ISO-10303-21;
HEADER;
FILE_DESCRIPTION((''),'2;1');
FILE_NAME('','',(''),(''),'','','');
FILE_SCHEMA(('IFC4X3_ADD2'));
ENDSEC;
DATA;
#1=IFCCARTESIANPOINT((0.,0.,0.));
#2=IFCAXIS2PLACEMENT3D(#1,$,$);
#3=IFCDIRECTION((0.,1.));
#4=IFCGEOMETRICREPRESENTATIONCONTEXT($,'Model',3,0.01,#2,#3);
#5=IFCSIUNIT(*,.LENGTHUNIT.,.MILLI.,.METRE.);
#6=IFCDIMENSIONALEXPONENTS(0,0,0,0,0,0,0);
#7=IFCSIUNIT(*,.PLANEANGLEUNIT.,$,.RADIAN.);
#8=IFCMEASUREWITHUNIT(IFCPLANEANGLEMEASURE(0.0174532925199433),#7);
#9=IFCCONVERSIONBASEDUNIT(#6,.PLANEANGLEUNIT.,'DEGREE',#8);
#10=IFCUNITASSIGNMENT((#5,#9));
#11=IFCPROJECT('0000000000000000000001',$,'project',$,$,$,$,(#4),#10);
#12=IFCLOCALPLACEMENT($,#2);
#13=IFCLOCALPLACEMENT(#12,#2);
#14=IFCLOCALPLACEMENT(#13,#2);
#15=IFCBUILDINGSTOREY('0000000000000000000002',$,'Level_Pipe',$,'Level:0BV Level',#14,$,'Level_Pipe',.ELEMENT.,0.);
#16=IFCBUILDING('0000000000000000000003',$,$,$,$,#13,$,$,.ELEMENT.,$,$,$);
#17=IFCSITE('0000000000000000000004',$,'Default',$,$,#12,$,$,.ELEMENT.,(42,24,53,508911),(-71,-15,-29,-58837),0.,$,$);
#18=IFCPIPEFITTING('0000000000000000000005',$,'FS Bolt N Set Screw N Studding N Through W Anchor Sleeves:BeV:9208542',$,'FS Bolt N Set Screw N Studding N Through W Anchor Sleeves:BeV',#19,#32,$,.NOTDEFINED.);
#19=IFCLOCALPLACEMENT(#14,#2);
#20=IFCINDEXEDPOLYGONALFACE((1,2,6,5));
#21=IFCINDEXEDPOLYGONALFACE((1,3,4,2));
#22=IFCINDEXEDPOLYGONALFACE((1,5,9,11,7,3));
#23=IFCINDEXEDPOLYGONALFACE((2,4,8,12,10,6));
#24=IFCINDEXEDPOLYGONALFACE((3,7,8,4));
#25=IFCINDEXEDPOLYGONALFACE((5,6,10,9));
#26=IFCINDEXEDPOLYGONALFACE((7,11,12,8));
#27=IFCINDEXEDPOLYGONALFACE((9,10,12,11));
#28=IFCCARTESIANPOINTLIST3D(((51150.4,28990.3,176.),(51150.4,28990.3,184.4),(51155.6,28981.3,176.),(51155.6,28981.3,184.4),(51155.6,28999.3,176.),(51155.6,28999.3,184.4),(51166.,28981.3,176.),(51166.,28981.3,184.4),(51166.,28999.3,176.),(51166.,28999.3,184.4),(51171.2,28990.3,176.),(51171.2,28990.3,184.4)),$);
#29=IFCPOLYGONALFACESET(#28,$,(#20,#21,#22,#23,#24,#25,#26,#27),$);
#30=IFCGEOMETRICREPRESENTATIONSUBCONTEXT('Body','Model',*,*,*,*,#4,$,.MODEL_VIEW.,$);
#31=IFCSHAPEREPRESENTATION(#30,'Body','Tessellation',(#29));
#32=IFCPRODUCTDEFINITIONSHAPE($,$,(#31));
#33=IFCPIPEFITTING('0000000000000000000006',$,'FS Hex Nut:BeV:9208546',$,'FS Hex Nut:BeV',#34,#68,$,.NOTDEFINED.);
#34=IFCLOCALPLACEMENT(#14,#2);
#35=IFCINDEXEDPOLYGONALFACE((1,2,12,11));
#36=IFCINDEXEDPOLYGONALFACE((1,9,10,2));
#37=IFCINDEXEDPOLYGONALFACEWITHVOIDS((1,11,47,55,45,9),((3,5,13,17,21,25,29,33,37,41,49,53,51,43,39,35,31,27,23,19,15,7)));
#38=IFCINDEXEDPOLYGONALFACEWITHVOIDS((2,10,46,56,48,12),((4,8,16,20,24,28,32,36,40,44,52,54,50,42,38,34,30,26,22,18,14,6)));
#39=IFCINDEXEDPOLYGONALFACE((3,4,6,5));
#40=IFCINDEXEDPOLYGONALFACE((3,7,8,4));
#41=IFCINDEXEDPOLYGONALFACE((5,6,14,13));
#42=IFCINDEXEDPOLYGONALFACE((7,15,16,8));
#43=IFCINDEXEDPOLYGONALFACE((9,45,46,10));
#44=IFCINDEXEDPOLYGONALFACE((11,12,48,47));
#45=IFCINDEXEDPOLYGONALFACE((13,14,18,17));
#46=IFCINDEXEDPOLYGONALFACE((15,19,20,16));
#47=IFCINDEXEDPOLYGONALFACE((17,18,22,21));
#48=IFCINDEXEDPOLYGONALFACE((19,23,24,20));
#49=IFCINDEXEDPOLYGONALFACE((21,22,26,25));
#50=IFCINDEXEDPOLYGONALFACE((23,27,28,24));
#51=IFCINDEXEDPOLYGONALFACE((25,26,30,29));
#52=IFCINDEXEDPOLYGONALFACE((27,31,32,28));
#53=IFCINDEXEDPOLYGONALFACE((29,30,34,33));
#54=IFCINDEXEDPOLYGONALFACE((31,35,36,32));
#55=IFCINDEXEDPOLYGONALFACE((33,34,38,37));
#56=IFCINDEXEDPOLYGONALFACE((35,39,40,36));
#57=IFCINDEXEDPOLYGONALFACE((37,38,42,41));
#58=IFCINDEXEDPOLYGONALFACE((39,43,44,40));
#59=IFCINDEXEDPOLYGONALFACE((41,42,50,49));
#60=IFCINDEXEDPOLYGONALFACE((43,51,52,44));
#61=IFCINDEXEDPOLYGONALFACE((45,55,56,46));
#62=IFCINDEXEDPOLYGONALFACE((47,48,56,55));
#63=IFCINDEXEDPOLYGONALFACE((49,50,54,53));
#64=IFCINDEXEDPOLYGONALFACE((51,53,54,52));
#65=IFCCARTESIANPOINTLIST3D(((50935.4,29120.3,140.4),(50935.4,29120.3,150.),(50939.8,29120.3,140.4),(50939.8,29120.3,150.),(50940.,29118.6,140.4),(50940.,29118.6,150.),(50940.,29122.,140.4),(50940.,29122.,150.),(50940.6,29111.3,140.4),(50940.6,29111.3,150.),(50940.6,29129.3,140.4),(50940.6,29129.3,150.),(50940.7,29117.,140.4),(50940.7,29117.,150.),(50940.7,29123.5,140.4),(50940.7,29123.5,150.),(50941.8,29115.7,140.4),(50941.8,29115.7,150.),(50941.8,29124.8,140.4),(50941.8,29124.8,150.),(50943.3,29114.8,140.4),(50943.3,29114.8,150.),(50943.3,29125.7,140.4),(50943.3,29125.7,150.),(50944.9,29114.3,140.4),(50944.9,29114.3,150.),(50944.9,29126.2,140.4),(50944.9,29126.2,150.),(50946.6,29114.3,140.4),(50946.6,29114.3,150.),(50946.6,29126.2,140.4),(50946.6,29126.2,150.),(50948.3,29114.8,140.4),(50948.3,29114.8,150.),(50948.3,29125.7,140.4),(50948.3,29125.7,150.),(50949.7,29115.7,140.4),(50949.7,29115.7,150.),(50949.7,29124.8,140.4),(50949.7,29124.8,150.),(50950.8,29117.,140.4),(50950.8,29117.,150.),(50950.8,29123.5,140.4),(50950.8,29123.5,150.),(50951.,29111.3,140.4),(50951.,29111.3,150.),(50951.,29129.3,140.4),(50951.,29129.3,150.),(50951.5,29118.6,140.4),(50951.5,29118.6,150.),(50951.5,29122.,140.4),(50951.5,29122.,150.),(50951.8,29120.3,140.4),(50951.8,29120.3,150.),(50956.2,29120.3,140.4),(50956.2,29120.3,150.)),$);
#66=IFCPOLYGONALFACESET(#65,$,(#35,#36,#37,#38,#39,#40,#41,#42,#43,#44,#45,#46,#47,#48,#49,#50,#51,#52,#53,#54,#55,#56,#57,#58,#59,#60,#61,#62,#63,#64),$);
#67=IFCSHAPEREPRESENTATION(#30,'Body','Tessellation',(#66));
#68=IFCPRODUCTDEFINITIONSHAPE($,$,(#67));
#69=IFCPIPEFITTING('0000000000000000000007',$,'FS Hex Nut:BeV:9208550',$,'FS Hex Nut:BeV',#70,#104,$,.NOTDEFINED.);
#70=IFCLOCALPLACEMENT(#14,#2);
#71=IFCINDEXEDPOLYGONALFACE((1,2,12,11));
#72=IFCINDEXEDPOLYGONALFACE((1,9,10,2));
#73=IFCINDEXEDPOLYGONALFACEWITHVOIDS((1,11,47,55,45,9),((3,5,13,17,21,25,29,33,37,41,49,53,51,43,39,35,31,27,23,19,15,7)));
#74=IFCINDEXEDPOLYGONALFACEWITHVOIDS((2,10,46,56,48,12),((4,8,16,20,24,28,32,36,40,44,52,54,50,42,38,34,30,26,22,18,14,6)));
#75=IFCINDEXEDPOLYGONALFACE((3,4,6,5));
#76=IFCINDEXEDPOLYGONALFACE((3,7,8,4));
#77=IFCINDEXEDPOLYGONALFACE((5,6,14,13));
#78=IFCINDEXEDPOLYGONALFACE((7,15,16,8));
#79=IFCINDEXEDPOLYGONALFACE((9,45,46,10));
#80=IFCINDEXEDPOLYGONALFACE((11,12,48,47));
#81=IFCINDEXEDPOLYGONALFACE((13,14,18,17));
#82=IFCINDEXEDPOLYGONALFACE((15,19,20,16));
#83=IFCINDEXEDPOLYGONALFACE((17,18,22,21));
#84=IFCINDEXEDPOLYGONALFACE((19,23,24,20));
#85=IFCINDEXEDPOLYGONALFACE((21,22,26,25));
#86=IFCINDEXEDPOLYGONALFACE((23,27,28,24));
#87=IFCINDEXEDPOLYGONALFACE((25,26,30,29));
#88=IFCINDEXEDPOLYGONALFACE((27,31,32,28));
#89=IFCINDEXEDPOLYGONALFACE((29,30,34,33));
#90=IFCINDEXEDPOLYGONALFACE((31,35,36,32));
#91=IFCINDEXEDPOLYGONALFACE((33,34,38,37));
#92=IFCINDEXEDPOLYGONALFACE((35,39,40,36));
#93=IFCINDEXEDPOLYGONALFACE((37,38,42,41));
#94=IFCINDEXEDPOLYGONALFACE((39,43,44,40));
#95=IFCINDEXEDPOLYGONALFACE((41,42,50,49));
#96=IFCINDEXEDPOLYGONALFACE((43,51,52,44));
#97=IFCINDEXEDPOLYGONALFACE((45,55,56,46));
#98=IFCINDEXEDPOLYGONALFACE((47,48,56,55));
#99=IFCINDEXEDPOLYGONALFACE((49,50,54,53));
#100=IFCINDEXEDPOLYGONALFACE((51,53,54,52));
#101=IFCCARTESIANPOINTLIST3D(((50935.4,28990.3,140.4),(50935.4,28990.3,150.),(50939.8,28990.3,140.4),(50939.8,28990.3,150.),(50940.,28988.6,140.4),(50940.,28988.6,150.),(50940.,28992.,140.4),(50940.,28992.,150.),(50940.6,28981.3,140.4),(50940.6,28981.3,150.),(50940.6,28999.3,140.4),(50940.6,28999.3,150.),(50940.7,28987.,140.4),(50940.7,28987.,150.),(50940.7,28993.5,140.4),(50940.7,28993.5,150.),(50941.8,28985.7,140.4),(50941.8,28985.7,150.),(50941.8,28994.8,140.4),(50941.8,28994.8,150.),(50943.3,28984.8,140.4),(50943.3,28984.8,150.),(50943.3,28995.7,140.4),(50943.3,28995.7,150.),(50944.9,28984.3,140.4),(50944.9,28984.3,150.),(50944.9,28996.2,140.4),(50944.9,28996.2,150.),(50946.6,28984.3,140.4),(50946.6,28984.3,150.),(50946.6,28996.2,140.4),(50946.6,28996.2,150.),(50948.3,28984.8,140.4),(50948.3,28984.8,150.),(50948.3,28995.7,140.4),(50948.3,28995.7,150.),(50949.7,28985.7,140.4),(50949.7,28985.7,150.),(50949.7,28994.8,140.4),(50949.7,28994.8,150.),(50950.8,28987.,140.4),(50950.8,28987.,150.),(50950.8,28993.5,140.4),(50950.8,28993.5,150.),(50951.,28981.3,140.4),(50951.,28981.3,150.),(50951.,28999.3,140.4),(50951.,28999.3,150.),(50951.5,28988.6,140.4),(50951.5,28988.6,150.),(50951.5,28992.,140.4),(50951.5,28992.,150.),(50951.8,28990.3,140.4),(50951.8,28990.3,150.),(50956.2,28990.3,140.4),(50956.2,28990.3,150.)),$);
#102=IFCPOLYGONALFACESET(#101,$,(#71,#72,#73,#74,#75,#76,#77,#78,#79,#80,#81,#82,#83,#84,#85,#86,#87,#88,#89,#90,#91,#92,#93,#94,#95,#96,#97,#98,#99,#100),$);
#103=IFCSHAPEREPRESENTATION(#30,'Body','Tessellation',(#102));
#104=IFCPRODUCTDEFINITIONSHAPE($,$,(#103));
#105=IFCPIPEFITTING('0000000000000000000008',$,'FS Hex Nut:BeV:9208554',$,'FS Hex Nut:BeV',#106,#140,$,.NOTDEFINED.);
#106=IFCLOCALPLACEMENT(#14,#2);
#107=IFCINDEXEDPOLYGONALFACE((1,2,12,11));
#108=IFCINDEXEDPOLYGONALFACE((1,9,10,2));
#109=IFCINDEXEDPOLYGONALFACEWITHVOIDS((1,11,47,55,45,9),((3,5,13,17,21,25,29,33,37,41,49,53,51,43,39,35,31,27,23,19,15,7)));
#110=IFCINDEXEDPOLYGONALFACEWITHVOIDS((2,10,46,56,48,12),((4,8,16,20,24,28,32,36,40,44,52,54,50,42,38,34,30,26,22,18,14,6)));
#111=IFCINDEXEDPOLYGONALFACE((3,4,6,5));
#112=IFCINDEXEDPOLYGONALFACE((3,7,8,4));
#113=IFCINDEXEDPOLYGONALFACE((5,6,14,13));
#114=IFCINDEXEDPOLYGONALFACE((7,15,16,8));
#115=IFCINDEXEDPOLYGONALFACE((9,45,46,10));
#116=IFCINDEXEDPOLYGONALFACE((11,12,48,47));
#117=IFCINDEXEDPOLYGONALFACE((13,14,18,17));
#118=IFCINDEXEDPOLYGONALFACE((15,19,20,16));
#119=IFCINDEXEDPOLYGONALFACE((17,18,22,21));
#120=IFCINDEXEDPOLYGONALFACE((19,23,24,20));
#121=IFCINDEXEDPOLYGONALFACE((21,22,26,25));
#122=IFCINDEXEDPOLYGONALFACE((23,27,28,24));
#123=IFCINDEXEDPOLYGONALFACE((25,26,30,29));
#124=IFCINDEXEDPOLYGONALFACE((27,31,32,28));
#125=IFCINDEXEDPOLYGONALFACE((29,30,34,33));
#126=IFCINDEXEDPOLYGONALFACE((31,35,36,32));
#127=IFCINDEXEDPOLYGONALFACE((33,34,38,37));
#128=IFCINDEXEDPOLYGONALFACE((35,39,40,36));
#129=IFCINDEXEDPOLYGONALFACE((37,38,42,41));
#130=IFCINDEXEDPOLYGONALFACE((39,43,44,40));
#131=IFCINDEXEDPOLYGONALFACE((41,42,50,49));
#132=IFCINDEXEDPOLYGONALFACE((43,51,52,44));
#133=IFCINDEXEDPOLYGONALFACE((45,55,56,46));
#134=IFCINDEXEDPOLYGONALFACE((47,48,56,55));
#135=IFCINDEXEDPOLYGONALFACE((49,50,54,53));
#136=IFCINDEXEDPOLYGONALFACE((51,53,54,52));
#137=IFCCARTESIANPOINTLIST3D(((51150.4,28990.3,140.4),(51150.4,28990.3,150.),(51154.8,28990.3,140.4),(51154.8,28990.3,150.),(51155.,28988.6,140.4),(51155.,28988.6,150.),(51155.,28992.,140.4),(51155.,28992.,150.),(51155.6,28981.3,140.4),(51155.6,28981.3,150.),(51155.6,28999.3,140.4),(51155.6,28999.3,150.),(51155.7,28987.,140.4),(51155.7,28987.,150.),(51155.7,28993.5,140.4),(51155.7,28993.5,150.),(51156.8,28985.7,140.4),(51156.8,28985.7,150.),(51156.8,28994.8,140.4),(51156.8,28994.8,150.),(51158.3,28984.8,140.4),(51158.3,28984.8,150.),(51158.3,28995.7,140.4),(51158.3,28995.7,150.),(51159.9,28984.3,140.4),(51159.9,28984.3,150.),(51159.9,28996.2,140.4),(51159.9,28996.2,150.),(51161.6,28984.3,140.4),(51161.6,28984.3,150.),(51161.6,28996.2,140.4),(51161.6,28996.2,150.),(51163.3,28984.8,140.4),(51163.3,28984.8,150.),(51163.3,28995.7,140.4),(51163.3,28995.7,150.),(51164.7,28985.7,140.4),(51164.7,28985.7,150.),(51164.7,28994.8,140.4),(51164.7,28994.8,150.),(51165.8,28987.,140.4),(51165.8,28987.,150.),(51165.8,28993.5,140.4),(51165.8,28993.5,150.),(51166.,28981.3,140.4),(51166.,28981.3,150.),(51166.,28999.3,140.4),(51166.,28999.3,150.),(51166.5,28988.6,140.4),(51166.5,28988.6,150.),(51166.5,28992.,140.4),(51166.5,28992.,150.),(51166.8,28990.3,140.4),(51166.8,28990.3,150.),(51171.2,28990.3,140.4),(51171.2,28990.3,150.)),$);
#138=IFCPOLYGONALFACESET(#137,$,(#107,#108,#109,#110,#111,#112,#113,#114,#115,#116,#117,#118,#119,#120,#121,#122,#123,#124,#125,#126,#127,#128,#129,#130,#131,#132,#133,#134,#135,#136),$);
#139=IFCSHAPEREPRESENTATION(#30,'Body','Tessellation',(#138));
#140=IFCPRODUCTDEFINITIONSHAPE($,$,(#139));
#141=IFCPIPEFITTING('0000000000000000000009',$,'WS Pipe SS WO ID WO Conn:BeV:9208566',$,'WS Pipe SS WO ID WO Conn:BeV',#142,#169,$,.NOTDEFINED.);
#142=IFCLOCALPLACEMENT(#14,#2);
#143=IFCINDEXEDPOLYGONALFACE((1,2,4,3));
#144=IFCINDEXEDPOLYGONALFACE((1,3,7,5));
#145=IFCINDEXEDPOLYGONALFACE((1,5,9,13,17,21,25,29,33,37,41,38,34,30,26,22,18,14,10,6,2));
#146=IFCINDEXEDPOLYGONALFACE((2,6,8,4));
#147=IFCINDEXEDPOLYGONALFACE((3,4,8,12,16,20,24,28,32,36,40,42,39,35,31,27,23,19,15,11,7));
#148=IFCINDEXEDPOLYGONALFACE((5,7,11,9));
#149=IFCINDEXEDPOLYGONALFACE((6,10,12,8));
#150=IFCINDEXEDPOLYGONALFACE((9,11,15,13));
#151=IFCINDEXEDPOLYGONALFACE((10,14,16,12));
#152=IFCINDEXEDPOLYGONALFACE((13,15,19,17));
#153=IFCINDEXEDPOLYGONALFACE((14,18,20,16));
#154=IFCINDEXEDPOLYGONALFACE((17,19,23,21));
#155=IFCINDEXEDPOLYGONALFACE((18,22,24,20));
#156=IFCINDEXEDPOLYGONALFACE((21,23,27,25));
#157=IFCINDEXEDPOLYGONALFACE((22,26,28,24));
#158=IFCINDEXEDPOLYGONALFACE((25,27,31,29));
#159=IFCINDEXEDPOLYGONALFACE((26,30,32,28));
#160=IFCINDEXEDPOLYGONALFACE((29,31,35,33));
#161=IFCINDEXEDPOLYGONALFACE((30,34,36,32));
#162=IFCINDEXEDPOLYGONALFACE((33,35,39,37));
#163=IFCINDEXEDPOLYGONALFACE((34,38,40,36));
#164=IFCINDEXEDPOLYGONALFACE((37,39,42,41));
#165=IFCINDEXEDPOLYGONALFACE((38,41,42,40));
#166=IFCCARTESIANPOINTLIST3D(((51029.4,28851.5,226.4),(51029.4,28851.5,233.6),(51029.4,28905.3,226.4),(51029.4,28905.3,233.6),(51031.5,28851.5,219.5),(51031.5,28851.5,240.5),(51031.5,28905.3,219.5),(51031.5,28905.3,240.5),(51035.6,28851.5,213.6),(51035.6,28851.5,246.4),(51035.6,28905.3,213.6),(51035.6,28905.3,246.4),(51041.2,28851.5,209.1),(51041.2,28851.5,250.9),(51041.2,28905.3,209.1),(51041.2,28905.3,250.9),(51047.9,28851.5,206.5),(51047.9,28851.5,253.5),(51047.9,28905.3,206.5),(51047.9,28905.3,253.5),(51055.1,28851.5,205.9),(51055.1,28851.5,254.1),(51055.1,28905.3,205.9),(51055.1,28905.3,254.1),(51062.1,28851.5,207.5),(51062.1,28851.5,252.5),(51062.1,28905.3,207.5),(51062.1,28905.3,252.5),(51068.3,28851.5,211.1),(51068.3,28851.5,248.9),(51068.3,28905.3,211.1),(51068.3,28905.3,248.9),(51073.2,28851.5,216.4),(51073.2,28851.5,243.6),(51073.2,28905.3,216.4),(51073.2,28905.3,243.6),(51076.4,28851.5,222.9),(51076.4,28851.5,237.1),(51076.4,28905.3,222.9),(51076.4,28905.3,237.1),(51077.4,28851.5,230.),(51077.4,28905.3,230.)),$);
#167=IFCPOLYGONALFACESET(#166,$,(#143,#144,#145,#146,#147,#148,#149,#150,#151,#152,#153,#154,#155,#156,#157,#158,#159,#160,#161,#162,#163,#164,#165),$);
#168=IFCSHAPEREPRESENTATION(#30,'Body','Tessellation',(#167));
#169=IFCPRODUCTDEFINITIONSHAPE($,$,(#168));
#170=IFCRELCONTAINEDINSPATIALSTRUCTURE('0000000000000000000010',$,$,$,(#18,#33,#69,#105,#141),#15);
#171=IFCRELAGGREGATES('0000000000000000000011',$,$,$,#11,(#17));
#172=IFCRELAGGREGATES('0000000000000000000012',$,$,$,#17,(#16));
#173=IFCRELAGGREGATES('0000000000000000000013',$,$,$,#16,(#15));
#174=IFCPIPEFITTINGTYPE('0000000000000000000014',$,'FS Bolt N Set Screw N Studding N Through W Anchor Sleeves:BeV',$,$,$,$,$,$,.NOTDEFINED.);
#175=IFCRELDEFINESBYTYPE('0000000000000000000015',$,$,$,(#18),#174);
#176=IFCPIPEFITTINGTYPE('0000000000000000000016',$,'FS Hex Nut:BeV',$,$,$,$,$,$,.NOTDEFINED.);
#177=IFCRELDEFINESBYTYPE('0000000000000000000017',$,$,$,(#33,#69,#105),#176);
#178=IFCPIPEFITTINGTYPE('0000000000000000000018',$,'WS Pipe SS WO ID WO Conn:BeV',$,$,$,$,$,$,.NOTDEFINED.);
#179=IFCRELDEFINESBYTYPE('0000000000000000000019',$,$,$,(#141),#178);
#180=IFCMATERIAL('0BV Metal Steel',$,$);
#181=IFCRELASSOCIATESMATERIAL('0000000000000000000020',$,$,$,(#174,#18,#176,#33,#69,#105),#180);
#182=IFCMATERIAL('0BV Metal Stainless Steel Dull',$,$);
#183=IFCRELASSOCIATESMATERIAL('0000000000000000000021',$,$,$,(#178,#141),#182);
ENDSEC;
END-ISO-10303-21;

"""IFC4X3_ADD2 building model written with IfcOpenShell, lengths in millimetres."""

from ifc_helpers import new_model, entity, si_unit, converted_unit, direction, frame, frame_2d, origin, place, context, subcontext, project, spatial, polyline, circle_curve, parameter, trimmed, segment, composite_curve, circle, outline, extrude, source, transform, mapped, material, type_object, type_shapes, element, save


model = new_model("IFC4X3_ADD2")

# Units and contexts
model_context = context("Model", 3, precision=0.01, world=origin(), true_north=direction((0.0, 1.0)))
body_context = subcontext(model_context, "Body", "Model", "MODEL_VIEW")
ifc_project = project(units=[si_unit("LENGTHUNIT", "METRE", prefix="MILLI"), converted_unit("PLANEANGLEUNIT", "DEGREE", entity("IfcPlaneAngleMeasure", 0.0174532925199433), si_unit("PLANEANGLEUNIT", "RADIAN"), dimensions=[0, 0, 0, 0, 0, 0, 0])], contexts=[model_context])

# Site, building, storey
site_placement = place(None, origin())
site = spatial("IfcSite", under=ifc_project, at=site_placement, Name="Default", CompositionType="ELEMENT", RefLatitude=(42, 24, 53, 508911), RefLongitude=(-71, -15, -29, -58837), RefElevation=0.0)
building_placement = place(site_placement, origin())
building = spatial("IfcBuilding", under=site, at=building_placement, CompositionType="ELEMENT")
storey_placement = place(building_placement, origin())
storey = spatial("IfcBuildingStorey", under=building, at=storey_placement, Name="Level_Pipe", ObjectType="Level:0BV Level", LongName="Level_Pipe", CompositionType="ELEMENT", Elevation=0.0)

# Pipe fittings
ifc_material_1 = material(Name="0BV Metal Stainless Steel Dull")
ifc_material_2 = material(Name="0BV Metal Steel")
pipe_fitting_type_1 = type_object("IfcPipeFittingType", Name="FS Bolt N Set Screw N Studding N Through W Anchor Sleeves:BeV", PredefinedType="NOTDEFINED", material=ifc_material_2)
shared_shape_1 = source(origin(), body_context, "Body", "SweptSolid", [
    extrude(outline(polyline([(-5.2, -9.0), (5.2, -9.0), (10.4, 0.0), (5.2, 9.0), (-5.2, 9.0), (-10.4, 0.0), (-5.2, -9.0)])), frame((-8.4, 0.0, 0.0), z_axis=(1.0, 0.0, 0.0), x_axis=(0.0, -0.5, -0.866025)), (0.0, 0.0, 1.0), 8.4),
])
type_shapes(pipe_fitting_type_1, [shared_shape_1])
pipe_fitting_1_placement = place(storey_placement, frame((51160.8, 28990.3, 176.0), z_axis=(0.0, 1.0, 0.0), x_axis=(0.0, 0.0, -1.0)))
element("IfcPipeFitting", 1, at=pipe_fitting_1_placement, inside=storey, type_object=pipe_fitting_type_1, material=ifc_material_2, Name="FS Bolt N Set Screw N Studding N Through W Anchor Sleeves:BeV:9208542", ObjectType="FS Bolt N Set Screw N Studding N Through W Anchor Sleeves:BeV", PredefinedType="NOTDEFINED", context=body_context, shape_type="MappedRepresentation", body=[
    mapped(shared_shape_1, transform((0.0, 0.0, 0.0), scale=1.0)),
])
pipe_fitting_type_2 = type_object("IfcPipeFittingType", Name="FS Hex Nut:BeV", PredefinedType="NOTDEFINED", material=ifc_material_2)
shared_shape_2 = source(origin(), body_context, "Body", "SweptSolid", [
    extrude(outline(polyline([(-5.2, -9.0), (5.2, -9.0), (10.4, 0.0), (5.2, 9.0), (-5.2, 9.0), (-10.4, 0.0), (-5.2, -9.0)]), holes=[composite_curve([segment(trimmed(circle_curve(frame_2d((0.0, 0.0), x_axis=(-0.5, 0.866025)), 6.0), [parameter(0.0)], [parameter(180.0)], True, "PARAMETER"), False, "CONTINUOUS"), segment(trimmed(circle_curve(frame_2d((0.0, 0.0), x_axis=(-0.5, 0.866025)), 6.0), [parameter(180.0)], [parameter(360.0)], True, "PARAMETER"), False, "CONTINUOUS")], self_intersect=False)]), frame((0.0, 10.4, 9.0), z_axis=(1.0, 0.0, 0.0), x_axis=(0.0, -0.5, -0.866025)), (0.0, 0.0, 1.0), 9.6),
])
type_shapes(pipe_fitting_type_2, [shared_shape_2])
for number, where, z_axis, x_axis, name in (
    (2, (50956.2, 29111.3, 150.0), (0.0, 1.0, 0.0), (0.0, 0.0, -1.0), "FS Hex Nut:BeV:9208546"),
    (3, (50956.2, 28981.3, 150.0), (0.0, 1.0, 0.0), (0.0, 0.0, -1.0), "FS Hex Nut:BeV:9208550"),
    (4, (51171.2, 28981.3, 150.0), (0.0, 1.0, 0.0), (0.0, 0.0, -1.0), "FS Hex Nut:BeV:9208554"),
):
    element("IfcPipeFitting", number, at=place(storey_placement, frame(where, z_axis=z_axis, x_axis=x_axis)), inside=storey, type_object=pipe_fitting_type_2, material=ifc_material_2, Name=name, ObjectType="FS Hex Nut:BeV", PredefinedType="NOTDEFINED", context=body_context, shape_type="MappedRepresentation", body=[
        mapped(shared_shape_2, transform((0.0, 0.0, 0.0), scale=1.0)),
    ])
pipe_fitting_type_3 = type_object("IfcPipeFittingType", Name="WS Pipe SS WO ID WO Conn:BeV", PredefinedType="NOTDEFINED", material=ifc_material_1)
shared_shape_3 = source(origin(), body_context, "Body", "SweptSolid", [
    extrude(circle(Radius=24.1, at=frame_2d((0.0, 0.0), x_axis=(1.0, 0.0))), frame((-26.9, 0.0, 0.0), z_axis=(1.0, 0.0, 0.0), x_axis=(0.0, 1.0, 0.0)), (0.0, 0.0, 1.0), 53.8),
])
type_shapes(pipe_fitting_type_3, [shared_shape_3])
pipe_fitting_2_placement = place(storey_placement, frame((51053.3, 28878.4, 230.0), z_axis=(0.0, 0.0, 1.0), x_axis=(0.0, -1.0, 0.0)))
element("IfcPipeFitting", 5, at=pipe_fitting_2_placement, inside=storey, type_object=pipe_fitting_type_3, material=ifc_material_1, Name="WS Pipe SS WO ID WO Conn:BeV:9208566", ObjectType="WS Pipe SS WO ID WO Conn:BeV", PredefinedType="NOTDEFINED", context=body_context, shape_type="MappedRepresentation", body=[
    mapped(shared_shape_3, transform((0.0, 0.0, 0.0), scale=1.0)),
])

save(model, "model.ifc")
